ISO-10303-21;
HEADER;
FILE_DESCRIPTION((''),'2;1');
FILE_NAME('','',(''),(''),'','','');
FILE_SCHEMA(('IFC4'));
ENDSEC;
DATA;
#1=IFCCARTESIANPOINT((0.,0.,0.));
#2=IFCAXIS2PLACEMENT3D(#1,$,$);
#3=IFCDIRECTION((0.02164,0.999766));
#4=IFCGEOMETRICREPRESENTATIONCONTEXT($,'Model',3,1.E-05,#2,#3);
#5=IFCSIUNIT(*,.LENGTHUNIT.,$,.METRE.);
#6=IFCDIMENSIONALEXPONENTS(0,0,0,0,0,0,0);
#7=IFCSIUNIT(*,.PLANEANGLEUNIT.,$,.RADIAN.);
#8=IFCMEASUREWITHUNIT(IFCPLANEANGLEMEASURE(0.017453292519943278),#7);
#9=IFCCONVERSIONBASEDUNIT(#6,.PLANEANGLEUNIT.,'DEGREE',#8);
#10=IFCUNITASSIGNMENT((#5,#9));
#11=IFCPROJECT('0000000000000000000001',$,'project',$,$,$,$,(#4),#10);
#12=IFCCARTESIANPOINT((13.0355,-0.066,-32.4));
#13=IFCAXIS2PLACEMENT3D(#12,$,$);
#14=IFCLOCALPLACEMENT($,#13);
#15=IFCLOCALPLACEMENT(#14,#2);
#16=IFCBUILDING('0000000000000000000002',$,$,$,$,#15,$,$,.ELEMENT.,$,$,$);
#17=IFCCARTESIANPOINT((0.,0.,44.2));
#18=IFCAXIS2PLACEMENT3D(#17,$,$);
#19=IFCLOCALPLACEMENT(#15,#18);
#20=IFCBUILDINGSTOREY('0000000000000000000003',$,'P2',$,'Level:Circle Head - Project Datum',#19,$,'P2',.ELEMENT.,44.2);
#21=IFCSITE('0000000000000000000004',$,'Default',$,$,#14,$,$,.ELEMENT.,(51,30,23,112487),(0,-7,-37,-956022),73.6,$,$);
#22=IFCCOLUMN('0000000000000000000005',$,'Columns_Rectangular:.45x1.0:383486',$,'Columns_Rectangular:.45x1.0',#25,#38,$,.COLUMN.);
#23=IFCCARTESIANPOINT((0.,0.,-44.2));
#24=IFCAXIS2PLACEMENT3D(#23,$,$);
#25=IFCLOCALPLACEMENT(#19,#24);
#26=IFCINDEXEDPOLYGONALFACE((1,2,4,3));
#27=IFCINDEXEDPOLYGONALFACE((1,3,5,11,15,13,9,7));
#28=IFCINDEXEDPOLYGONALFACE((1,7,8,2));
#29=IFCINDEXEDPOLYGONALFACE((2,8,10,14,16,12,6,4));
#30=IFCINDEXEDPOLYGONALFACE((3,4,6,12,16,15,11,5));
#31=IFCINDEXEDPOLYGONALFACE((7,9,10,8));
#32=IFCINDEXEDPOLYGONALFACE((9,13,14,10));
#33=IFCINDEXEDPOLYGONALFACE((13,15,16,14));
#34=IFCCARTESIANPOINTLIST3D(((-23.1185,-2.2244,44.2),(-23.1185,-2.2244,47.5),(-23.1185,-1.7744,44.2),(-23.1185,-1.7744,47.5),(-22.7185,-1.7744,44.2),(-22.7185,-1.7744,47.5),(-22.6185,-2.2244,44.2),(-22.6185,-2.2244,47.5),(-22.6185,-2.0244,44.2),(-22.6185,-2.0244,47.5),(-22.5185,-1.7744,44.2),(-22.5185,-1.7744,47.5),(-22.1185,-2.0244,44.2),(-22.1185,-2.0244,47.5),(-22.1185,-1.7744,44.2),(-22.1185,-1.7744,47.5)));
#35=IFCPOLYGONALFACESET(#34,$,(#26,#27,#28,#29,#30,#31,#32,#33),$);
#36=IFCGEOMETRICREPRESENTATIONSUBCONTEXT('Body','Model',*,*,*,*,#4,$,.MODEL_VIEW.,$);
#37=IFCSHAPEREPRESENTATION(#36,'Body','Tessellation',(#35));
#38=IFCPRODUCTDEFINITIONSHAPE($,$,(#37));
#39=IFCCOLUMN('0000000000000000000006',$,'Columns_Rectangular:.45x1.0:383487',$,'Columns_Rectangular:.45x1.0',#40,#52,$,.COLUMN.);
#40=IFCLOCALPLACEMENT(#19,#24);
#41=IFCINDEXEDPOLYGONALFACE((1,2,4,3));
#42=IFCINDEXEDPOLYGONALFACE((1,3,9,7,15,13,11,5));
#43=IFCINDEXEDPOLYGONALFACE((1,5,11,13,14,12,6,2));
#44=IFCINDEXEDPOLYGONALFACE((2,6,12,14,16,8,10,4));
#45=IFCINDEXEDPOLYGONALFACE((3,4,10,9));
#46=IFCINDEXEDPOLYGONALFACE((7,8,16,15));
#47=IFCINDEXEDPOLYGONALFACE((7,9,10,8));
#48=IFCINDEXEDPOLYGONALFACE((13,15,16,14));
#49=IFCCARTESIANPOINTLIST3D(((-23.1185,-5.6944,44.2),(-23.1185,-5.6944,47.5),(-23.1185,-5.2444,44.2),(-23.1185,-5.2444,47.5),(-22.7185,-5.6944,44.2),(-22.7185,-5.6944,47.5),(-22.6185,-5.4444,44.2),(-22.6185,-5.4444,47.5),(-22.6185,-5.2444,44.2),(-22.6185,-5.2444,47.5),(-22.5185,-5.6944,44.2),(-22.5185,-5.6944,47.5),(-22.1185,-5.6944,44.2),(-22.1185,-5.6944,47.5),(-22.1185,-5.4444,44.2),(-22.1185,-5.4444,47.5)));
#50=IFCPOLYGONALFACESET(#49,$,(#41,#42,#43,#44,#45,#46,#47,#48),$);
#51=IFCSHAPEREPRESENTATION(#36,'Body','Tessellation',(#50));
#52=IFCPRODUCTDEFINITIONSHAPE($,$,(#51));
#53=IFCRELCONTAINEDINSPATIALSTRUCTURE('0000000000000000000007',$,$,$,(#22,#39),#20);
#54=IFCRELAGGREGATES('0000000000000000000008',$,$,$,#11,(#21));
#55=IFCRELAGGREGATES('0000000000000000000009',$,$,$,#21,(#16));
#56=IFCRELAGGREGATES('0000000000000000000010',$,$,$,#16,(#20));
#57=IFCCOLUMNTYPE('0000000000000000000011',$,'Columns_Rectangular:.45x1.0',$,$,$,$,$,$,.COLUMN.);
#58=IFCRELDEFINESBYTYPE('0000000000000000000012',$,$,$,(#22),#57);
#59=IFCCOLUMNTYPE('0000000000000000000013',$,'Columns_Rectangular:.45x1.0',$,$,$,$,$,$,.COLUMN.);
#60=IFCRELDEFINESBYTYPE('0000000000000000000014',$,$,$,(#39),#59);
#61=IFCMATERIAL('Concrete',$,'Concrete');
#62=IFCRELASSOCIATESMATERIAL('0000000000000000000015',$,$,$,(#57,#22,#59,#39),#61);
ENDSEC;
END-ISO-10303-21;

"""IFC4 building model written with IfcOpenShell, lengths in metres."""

from ifc_helpers import new_model, entity, si_unit, converted_unit, direction, frame, origin, place, context, subcontext, project, spatial, indexed_curve, outline, extrude, source, transform, mapped, material, type_object, type_shapes, element, save


model = new_model("IFC4")

# Units and contexts
model_context = context("Model", 3, precision=1e-05, world=origin(), true_north=direction((0.02164, 0.999766)))
body_context = subcontext(model_context, "Body", "Model", "MODEL_VIEW")
ifc_project = project(units=[si_unit("LENGTHUNIT", "METRE"), converted_unit("PLANEANGLEUNIT", "DEGREE", entity("IfcPlaneAngleMeasure", 0.017453292519943278), si_unit("PLANEANGLEUNIT", "RADIAN"), dimensions=[0, 0, 0, 0, 0, 0, 0])], contexts=[model_context])

# Site, building, storey
site_placement = place(None, frame((13.0355, -0.066, -32.4)))
site = spatial("IfcSite", under=ifc_project, at=site_placement, Name="Default", CompositionType="ELEMENT", RefLatitude=(51, 30, 23, 112487), RefLongitude=(0, -7, -37, -956022), RefElevation=73.6)
building_placement = place(site_placement, origin())
building = spatial("IfcBuilding", under=site, at=building_placement, CompositionType="ELEMENT")
storey_placement = place(building_placement, frame((0.0, 0.0, 44.2)))
storey = spatial("IfcBuildingStorey", under=building, at=storey_placement, Name="P2", ObjectType="Level:Circle Head - Project Datum", LongName="P2", CompositionType="ELEMENT", Elevation=44.2)

# Columns
ifc_material = material(Name="Concrete", Category="Concrete")
column_type_1 = type_object("IfcColumnType", Name="Columns_Rectangular:.45x1.0", PredefinedType="COLUMN", material=ifc_material)
shared_shape_1 = source(origin(), body_context, "Body", "SweptSolid", [
    extrude(outline(indexed_curve([(-0.5, -0.275), (0.0, -0.275), (0.0, -0.075), (0.5, -0.075), (0.5, 0.175), (0.1, 0.175), (-0.1, 0.175), (-0.5, 0.175), (-0.5, -0.275)], self_intersect=False)), frame((-22.6185, -1.9494, 44.2)), (0.0, 0.0, 1.0), 3.3),
])
type_shapes(column_type_1, [shared_shape_1])
column_1_placement = place(storey_placement, frame((0.0, 0.0, -44.2)))
element("IfcColumn", 1, at=column_1_placement, inside=storey, type_object=column_type_1, material=ifc_material, Name="Columns_Rectangular:.45x1.0:383486", ObjectType="Columns_Rectangular:.45x1.0", PredefinedType="COLUMN", context=body_context, shape_type="MappedRepresentation", body=[
    mapped(shared_shape_1, transform((0.0, 0.0, 0.0), scale=1.0)),
])
column_type_2 = type_object("IfcColumnType", Name="Columns_Rectangular:.45x1.0", PredefinedType="COLUMN", material=ifc_material)
shared_shape_2 = source(origin(), body_context, "Body", "SweptSolid", [
    extrude(outline(indexed_curve([(-0.175, -0.5), (0.075, -0.5), (0.075, 0.0), (0.275, 0.0), (0.275, 0.5), (-0.175, 0.5), (-0.175, 0.1), (-0.175, -0.1), (-0.175, -0.5)], self_intersect=False)), frame((-22.6185, -5.5194, 44.2), z_axis=(0.0, 0.0, 1.0), x_axis=(0.0, 1.0, 0.0)), (0.0, 0.0, 1.0), 3.3),
])
type_shapes(column_type_2, [shared_shape_2])
column_2_placement = place(storey_placement, frame((0.0, 0.0, -44.2)))
element("IfcColumn", 2, at=column_2_placement, inside=storey, type_object=column_type_2, material=ifc_material, Name="Columns_Rectangular:.45x1.0:383487", ObjectType="Columns_Rectangular:.45x1.0", PredefinedType="COLUMN", context=body_context, shape_type="MappedRepresentation", body=[
    mapped(shared_shape_2, transform((0.0, 0.0, 0.0), scale=1.0)),
])

save(model, "model.ifc")
